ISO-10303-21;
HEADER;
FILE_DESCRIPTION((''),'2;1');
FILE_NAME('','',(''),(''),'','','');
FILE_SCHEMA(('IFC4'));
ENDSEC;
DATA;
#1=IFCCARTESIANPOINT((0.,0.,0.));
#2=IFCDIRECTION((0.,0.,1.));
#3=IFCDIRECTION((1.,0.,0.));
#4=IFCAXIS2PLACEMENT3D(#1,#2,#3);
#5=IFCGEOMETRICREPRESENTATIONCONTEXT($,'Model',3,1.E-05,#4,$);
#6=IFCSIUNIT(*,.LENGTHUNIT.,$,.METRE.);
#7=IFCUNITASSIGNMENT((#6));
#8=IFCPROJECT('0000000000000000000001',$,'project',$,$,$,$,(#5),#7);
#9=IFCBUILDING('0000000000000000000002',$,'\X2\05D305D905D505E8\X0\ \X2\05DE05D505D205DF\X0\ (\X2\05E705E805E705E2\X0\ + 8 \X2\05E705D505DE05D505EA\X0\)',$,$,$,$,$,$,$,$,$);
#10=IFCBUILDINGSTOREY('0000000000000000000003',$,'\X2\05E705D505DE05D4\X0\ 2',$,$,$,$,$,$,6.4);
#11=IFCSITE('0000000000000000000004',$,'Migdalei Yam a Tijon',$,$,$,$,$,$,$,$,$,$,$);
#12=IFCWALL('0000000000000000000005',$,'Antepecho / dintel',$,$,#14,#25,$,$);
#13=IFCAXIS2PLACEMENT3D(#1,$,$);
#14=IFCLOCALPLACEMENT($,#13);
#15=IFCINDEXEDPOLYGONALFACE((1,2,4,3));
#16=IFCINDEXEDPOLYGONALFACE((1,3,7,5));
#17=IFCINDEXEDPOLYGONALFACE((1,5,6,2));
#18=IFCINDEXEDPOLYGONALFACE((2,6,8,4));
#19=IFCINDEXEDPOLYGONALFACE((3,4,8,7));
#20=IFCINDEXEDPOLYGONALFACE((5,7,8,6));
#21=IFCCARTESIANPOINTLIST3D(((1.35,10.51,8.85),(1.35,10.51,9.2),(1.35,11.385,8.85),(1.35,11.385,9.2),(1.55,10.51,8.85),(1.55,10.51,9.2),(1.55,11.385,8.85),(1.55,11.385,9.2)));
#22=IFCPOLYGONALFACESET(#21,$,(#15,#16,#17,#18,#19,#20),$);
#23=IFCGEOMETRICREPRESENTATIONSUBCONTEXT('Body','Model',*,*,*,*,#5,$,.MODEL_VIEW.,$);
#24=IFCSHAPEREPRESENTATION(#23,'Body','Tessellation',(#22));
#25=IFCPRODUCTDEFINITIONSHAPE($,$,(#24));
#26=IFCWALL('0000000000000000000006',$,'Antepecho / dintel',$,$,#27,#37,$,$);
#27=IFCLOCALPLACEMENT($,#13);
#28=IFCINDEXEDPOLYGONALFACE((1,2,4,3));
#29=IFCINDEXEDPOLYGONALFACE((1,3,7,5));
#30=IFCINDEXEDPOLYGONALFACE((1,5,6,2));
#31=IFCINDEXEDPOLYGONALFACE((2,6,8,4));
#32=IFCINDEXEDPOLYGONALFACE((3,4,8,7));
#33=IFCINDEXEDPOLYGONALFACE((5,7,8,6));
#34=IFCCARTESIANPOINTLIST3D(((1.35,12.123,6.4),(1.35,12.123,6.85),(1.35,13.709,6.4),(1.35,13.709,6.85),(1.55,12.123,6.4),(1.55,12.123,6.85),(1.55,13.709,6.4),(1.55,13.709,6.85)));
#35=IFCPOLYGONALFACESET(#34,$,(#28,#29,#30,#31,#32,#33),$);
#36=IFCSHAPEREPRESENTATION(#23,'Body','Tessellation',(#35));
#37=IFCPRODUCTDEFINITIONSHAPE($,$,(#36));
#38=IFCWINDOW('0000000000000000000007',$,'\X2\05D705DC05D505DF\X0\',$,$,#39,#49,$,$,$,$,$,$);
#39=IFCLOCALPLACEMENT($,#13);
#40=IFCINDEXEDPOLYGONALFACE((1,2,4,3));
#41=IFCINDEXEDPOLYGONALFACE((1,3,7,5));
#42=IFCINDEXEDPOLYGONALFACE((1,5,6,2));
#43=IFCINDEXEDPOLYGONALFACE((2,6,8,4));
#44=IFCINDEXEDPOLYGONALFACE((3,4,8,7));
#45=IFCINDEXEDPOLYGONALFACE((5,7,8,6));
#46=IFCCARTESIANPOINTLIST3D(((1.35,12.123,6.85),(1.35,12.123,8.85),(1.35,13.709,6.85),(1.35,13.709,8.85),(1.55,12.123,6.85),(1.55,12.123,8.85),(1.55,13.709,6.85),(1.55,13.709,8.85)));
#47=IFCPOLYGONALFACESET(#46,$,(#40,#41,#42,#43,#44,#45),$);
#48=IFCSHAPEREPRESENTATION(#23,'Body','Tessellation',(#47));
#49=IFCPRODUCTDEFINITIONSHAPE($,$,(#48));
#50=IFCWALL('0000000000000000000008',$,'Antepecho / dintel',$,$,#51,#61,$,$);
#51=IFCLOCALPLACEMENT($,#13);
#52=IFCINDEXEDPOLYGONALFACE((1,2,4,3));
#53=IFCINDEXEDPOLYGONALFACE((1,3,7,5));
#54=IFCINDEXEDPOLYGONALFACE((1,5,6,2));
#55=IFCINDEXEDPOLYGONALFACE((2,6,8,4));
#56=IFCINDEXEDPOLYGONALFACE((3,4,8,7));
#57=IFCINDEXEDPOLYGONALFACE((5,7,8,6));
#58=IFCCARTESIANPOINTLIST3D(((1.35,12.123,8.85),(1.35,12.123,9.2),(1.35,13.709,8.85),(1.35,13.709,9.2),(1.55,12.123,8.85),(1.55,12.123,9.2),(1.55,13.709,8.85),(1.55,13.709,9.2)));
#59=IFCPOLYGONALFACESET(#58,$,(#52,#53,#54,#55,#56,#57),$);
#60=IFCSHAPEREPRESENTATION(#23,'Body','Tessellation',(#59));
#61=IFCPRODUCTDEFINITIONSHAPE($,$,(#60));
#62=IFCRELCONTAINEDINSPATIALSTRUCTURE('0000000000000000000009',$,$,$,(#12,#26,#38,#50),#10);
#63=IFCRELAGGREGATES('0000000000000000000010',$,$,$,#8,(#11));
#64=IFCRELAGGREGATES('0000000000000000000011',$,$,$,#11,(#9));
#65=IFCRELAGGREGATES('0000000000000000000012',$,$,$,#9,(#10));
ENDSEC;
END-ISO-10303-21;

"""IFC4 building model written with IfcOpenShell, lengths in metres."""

from ifc_helpers import new_model, si_unit, frame, origin_with_axes, context, subcontext, project, spatial, line, indexed_curve, outline, extrude, element, save


model = new_model("IFC4")

# Units and contexts
model_context = context("Model", 3, precision=1e-05, world=origin_with_axes())
body_context = subcontext(model_context, "Body", "Model", "MODEL_VIEW")
ifc_project = project(units=[si_unit("LENGTHUNIT", "METRE")], contexts=[model_context])

# Site, building, storey
site = spatial("IfcSite", under=ifc_project, Name="Migdalei Yam a Tijon")
building = spatial("IfcBuilding", under=site, Name="דיור מוגן (קרקע + 8 קומות)")
storey = spatial("IfcBuildingStorey", under=building, Name="קומה 2", Elevation=6.4)

# Walls
element("IfcWall", 1, inside=storey, Name="Antepecho / dintel", context=body_context, shape_type="SweptSolid", body=[
    extrude(outline(indexed_curve([(0.0, 0.0), (0.2, 0.0), (0.2, 0.875), (0.0, 0.875)], segments=[line(1, 2, 3, 4, 1)])), frame((1.35, 10.51, 8.85), z_axis=(0.0, 0.0, 1.0), x_axis=(1.0, 0.0, 0.0)), (0.0, 0.0, 1.0), 0.35),
])
element("IfcWall", 2, inside=storey, Name="Antepecho / dintel", context=body_context, shape_type="SweptSolid", body=[
    extrude(outline(indexed_curve([(0.0, 0.0), (0.2, 0.0), (0.2, 1.586), (0.0, 1.586)], segments=[line(1, 2, 3, 4, 1)])), frame((1.35, 12.123, 6.4), z_axis=(0.0, 0.0, 1.0), x_axis=(1.0, 0.0, 0.0)), (0.0, 0.0, 1.0), 0.45),
])

# Window
element("IfcWindow", 3, inside=storey, Name="חלון", context=body_context, shape_type="SweptSolid", body=[
    extrude(outline(indexed_curve([(0.0, 0.0), (0.2, 0.0), (0.2, 1.586), (0.0, 1.586)], segments=[line(1, 2, 3, 4, 1)])), frame((1.35, 12.123, 6.85), z_axis=(0.0, 0.0, 1.0), x_axis=(1.0, 0.0, 0.0)), (0.0, 0.0, 1.0), 2.0),
])

# Wall
element("IfcWall", 4, inside=storey, Name="Antepecho / dintel", context=body_context, shape_type="SweptSolid", body=[
    extrude(outline(indexed_curve([(0.0, 0.0), (0.2, 0.0), (0.2, 1.586), (0.0, 1.586)], segments=[line(1, 2, 3, 4, 1)])), frame((1.35, 12.123, 8.85), z_axis=(0.0, 0.0, 1.0), x_axis=(1.0, 0.0, 0.0)), (0.0, 0.0, 1.0), 0.35),
])

save(model, "model.ifc")
